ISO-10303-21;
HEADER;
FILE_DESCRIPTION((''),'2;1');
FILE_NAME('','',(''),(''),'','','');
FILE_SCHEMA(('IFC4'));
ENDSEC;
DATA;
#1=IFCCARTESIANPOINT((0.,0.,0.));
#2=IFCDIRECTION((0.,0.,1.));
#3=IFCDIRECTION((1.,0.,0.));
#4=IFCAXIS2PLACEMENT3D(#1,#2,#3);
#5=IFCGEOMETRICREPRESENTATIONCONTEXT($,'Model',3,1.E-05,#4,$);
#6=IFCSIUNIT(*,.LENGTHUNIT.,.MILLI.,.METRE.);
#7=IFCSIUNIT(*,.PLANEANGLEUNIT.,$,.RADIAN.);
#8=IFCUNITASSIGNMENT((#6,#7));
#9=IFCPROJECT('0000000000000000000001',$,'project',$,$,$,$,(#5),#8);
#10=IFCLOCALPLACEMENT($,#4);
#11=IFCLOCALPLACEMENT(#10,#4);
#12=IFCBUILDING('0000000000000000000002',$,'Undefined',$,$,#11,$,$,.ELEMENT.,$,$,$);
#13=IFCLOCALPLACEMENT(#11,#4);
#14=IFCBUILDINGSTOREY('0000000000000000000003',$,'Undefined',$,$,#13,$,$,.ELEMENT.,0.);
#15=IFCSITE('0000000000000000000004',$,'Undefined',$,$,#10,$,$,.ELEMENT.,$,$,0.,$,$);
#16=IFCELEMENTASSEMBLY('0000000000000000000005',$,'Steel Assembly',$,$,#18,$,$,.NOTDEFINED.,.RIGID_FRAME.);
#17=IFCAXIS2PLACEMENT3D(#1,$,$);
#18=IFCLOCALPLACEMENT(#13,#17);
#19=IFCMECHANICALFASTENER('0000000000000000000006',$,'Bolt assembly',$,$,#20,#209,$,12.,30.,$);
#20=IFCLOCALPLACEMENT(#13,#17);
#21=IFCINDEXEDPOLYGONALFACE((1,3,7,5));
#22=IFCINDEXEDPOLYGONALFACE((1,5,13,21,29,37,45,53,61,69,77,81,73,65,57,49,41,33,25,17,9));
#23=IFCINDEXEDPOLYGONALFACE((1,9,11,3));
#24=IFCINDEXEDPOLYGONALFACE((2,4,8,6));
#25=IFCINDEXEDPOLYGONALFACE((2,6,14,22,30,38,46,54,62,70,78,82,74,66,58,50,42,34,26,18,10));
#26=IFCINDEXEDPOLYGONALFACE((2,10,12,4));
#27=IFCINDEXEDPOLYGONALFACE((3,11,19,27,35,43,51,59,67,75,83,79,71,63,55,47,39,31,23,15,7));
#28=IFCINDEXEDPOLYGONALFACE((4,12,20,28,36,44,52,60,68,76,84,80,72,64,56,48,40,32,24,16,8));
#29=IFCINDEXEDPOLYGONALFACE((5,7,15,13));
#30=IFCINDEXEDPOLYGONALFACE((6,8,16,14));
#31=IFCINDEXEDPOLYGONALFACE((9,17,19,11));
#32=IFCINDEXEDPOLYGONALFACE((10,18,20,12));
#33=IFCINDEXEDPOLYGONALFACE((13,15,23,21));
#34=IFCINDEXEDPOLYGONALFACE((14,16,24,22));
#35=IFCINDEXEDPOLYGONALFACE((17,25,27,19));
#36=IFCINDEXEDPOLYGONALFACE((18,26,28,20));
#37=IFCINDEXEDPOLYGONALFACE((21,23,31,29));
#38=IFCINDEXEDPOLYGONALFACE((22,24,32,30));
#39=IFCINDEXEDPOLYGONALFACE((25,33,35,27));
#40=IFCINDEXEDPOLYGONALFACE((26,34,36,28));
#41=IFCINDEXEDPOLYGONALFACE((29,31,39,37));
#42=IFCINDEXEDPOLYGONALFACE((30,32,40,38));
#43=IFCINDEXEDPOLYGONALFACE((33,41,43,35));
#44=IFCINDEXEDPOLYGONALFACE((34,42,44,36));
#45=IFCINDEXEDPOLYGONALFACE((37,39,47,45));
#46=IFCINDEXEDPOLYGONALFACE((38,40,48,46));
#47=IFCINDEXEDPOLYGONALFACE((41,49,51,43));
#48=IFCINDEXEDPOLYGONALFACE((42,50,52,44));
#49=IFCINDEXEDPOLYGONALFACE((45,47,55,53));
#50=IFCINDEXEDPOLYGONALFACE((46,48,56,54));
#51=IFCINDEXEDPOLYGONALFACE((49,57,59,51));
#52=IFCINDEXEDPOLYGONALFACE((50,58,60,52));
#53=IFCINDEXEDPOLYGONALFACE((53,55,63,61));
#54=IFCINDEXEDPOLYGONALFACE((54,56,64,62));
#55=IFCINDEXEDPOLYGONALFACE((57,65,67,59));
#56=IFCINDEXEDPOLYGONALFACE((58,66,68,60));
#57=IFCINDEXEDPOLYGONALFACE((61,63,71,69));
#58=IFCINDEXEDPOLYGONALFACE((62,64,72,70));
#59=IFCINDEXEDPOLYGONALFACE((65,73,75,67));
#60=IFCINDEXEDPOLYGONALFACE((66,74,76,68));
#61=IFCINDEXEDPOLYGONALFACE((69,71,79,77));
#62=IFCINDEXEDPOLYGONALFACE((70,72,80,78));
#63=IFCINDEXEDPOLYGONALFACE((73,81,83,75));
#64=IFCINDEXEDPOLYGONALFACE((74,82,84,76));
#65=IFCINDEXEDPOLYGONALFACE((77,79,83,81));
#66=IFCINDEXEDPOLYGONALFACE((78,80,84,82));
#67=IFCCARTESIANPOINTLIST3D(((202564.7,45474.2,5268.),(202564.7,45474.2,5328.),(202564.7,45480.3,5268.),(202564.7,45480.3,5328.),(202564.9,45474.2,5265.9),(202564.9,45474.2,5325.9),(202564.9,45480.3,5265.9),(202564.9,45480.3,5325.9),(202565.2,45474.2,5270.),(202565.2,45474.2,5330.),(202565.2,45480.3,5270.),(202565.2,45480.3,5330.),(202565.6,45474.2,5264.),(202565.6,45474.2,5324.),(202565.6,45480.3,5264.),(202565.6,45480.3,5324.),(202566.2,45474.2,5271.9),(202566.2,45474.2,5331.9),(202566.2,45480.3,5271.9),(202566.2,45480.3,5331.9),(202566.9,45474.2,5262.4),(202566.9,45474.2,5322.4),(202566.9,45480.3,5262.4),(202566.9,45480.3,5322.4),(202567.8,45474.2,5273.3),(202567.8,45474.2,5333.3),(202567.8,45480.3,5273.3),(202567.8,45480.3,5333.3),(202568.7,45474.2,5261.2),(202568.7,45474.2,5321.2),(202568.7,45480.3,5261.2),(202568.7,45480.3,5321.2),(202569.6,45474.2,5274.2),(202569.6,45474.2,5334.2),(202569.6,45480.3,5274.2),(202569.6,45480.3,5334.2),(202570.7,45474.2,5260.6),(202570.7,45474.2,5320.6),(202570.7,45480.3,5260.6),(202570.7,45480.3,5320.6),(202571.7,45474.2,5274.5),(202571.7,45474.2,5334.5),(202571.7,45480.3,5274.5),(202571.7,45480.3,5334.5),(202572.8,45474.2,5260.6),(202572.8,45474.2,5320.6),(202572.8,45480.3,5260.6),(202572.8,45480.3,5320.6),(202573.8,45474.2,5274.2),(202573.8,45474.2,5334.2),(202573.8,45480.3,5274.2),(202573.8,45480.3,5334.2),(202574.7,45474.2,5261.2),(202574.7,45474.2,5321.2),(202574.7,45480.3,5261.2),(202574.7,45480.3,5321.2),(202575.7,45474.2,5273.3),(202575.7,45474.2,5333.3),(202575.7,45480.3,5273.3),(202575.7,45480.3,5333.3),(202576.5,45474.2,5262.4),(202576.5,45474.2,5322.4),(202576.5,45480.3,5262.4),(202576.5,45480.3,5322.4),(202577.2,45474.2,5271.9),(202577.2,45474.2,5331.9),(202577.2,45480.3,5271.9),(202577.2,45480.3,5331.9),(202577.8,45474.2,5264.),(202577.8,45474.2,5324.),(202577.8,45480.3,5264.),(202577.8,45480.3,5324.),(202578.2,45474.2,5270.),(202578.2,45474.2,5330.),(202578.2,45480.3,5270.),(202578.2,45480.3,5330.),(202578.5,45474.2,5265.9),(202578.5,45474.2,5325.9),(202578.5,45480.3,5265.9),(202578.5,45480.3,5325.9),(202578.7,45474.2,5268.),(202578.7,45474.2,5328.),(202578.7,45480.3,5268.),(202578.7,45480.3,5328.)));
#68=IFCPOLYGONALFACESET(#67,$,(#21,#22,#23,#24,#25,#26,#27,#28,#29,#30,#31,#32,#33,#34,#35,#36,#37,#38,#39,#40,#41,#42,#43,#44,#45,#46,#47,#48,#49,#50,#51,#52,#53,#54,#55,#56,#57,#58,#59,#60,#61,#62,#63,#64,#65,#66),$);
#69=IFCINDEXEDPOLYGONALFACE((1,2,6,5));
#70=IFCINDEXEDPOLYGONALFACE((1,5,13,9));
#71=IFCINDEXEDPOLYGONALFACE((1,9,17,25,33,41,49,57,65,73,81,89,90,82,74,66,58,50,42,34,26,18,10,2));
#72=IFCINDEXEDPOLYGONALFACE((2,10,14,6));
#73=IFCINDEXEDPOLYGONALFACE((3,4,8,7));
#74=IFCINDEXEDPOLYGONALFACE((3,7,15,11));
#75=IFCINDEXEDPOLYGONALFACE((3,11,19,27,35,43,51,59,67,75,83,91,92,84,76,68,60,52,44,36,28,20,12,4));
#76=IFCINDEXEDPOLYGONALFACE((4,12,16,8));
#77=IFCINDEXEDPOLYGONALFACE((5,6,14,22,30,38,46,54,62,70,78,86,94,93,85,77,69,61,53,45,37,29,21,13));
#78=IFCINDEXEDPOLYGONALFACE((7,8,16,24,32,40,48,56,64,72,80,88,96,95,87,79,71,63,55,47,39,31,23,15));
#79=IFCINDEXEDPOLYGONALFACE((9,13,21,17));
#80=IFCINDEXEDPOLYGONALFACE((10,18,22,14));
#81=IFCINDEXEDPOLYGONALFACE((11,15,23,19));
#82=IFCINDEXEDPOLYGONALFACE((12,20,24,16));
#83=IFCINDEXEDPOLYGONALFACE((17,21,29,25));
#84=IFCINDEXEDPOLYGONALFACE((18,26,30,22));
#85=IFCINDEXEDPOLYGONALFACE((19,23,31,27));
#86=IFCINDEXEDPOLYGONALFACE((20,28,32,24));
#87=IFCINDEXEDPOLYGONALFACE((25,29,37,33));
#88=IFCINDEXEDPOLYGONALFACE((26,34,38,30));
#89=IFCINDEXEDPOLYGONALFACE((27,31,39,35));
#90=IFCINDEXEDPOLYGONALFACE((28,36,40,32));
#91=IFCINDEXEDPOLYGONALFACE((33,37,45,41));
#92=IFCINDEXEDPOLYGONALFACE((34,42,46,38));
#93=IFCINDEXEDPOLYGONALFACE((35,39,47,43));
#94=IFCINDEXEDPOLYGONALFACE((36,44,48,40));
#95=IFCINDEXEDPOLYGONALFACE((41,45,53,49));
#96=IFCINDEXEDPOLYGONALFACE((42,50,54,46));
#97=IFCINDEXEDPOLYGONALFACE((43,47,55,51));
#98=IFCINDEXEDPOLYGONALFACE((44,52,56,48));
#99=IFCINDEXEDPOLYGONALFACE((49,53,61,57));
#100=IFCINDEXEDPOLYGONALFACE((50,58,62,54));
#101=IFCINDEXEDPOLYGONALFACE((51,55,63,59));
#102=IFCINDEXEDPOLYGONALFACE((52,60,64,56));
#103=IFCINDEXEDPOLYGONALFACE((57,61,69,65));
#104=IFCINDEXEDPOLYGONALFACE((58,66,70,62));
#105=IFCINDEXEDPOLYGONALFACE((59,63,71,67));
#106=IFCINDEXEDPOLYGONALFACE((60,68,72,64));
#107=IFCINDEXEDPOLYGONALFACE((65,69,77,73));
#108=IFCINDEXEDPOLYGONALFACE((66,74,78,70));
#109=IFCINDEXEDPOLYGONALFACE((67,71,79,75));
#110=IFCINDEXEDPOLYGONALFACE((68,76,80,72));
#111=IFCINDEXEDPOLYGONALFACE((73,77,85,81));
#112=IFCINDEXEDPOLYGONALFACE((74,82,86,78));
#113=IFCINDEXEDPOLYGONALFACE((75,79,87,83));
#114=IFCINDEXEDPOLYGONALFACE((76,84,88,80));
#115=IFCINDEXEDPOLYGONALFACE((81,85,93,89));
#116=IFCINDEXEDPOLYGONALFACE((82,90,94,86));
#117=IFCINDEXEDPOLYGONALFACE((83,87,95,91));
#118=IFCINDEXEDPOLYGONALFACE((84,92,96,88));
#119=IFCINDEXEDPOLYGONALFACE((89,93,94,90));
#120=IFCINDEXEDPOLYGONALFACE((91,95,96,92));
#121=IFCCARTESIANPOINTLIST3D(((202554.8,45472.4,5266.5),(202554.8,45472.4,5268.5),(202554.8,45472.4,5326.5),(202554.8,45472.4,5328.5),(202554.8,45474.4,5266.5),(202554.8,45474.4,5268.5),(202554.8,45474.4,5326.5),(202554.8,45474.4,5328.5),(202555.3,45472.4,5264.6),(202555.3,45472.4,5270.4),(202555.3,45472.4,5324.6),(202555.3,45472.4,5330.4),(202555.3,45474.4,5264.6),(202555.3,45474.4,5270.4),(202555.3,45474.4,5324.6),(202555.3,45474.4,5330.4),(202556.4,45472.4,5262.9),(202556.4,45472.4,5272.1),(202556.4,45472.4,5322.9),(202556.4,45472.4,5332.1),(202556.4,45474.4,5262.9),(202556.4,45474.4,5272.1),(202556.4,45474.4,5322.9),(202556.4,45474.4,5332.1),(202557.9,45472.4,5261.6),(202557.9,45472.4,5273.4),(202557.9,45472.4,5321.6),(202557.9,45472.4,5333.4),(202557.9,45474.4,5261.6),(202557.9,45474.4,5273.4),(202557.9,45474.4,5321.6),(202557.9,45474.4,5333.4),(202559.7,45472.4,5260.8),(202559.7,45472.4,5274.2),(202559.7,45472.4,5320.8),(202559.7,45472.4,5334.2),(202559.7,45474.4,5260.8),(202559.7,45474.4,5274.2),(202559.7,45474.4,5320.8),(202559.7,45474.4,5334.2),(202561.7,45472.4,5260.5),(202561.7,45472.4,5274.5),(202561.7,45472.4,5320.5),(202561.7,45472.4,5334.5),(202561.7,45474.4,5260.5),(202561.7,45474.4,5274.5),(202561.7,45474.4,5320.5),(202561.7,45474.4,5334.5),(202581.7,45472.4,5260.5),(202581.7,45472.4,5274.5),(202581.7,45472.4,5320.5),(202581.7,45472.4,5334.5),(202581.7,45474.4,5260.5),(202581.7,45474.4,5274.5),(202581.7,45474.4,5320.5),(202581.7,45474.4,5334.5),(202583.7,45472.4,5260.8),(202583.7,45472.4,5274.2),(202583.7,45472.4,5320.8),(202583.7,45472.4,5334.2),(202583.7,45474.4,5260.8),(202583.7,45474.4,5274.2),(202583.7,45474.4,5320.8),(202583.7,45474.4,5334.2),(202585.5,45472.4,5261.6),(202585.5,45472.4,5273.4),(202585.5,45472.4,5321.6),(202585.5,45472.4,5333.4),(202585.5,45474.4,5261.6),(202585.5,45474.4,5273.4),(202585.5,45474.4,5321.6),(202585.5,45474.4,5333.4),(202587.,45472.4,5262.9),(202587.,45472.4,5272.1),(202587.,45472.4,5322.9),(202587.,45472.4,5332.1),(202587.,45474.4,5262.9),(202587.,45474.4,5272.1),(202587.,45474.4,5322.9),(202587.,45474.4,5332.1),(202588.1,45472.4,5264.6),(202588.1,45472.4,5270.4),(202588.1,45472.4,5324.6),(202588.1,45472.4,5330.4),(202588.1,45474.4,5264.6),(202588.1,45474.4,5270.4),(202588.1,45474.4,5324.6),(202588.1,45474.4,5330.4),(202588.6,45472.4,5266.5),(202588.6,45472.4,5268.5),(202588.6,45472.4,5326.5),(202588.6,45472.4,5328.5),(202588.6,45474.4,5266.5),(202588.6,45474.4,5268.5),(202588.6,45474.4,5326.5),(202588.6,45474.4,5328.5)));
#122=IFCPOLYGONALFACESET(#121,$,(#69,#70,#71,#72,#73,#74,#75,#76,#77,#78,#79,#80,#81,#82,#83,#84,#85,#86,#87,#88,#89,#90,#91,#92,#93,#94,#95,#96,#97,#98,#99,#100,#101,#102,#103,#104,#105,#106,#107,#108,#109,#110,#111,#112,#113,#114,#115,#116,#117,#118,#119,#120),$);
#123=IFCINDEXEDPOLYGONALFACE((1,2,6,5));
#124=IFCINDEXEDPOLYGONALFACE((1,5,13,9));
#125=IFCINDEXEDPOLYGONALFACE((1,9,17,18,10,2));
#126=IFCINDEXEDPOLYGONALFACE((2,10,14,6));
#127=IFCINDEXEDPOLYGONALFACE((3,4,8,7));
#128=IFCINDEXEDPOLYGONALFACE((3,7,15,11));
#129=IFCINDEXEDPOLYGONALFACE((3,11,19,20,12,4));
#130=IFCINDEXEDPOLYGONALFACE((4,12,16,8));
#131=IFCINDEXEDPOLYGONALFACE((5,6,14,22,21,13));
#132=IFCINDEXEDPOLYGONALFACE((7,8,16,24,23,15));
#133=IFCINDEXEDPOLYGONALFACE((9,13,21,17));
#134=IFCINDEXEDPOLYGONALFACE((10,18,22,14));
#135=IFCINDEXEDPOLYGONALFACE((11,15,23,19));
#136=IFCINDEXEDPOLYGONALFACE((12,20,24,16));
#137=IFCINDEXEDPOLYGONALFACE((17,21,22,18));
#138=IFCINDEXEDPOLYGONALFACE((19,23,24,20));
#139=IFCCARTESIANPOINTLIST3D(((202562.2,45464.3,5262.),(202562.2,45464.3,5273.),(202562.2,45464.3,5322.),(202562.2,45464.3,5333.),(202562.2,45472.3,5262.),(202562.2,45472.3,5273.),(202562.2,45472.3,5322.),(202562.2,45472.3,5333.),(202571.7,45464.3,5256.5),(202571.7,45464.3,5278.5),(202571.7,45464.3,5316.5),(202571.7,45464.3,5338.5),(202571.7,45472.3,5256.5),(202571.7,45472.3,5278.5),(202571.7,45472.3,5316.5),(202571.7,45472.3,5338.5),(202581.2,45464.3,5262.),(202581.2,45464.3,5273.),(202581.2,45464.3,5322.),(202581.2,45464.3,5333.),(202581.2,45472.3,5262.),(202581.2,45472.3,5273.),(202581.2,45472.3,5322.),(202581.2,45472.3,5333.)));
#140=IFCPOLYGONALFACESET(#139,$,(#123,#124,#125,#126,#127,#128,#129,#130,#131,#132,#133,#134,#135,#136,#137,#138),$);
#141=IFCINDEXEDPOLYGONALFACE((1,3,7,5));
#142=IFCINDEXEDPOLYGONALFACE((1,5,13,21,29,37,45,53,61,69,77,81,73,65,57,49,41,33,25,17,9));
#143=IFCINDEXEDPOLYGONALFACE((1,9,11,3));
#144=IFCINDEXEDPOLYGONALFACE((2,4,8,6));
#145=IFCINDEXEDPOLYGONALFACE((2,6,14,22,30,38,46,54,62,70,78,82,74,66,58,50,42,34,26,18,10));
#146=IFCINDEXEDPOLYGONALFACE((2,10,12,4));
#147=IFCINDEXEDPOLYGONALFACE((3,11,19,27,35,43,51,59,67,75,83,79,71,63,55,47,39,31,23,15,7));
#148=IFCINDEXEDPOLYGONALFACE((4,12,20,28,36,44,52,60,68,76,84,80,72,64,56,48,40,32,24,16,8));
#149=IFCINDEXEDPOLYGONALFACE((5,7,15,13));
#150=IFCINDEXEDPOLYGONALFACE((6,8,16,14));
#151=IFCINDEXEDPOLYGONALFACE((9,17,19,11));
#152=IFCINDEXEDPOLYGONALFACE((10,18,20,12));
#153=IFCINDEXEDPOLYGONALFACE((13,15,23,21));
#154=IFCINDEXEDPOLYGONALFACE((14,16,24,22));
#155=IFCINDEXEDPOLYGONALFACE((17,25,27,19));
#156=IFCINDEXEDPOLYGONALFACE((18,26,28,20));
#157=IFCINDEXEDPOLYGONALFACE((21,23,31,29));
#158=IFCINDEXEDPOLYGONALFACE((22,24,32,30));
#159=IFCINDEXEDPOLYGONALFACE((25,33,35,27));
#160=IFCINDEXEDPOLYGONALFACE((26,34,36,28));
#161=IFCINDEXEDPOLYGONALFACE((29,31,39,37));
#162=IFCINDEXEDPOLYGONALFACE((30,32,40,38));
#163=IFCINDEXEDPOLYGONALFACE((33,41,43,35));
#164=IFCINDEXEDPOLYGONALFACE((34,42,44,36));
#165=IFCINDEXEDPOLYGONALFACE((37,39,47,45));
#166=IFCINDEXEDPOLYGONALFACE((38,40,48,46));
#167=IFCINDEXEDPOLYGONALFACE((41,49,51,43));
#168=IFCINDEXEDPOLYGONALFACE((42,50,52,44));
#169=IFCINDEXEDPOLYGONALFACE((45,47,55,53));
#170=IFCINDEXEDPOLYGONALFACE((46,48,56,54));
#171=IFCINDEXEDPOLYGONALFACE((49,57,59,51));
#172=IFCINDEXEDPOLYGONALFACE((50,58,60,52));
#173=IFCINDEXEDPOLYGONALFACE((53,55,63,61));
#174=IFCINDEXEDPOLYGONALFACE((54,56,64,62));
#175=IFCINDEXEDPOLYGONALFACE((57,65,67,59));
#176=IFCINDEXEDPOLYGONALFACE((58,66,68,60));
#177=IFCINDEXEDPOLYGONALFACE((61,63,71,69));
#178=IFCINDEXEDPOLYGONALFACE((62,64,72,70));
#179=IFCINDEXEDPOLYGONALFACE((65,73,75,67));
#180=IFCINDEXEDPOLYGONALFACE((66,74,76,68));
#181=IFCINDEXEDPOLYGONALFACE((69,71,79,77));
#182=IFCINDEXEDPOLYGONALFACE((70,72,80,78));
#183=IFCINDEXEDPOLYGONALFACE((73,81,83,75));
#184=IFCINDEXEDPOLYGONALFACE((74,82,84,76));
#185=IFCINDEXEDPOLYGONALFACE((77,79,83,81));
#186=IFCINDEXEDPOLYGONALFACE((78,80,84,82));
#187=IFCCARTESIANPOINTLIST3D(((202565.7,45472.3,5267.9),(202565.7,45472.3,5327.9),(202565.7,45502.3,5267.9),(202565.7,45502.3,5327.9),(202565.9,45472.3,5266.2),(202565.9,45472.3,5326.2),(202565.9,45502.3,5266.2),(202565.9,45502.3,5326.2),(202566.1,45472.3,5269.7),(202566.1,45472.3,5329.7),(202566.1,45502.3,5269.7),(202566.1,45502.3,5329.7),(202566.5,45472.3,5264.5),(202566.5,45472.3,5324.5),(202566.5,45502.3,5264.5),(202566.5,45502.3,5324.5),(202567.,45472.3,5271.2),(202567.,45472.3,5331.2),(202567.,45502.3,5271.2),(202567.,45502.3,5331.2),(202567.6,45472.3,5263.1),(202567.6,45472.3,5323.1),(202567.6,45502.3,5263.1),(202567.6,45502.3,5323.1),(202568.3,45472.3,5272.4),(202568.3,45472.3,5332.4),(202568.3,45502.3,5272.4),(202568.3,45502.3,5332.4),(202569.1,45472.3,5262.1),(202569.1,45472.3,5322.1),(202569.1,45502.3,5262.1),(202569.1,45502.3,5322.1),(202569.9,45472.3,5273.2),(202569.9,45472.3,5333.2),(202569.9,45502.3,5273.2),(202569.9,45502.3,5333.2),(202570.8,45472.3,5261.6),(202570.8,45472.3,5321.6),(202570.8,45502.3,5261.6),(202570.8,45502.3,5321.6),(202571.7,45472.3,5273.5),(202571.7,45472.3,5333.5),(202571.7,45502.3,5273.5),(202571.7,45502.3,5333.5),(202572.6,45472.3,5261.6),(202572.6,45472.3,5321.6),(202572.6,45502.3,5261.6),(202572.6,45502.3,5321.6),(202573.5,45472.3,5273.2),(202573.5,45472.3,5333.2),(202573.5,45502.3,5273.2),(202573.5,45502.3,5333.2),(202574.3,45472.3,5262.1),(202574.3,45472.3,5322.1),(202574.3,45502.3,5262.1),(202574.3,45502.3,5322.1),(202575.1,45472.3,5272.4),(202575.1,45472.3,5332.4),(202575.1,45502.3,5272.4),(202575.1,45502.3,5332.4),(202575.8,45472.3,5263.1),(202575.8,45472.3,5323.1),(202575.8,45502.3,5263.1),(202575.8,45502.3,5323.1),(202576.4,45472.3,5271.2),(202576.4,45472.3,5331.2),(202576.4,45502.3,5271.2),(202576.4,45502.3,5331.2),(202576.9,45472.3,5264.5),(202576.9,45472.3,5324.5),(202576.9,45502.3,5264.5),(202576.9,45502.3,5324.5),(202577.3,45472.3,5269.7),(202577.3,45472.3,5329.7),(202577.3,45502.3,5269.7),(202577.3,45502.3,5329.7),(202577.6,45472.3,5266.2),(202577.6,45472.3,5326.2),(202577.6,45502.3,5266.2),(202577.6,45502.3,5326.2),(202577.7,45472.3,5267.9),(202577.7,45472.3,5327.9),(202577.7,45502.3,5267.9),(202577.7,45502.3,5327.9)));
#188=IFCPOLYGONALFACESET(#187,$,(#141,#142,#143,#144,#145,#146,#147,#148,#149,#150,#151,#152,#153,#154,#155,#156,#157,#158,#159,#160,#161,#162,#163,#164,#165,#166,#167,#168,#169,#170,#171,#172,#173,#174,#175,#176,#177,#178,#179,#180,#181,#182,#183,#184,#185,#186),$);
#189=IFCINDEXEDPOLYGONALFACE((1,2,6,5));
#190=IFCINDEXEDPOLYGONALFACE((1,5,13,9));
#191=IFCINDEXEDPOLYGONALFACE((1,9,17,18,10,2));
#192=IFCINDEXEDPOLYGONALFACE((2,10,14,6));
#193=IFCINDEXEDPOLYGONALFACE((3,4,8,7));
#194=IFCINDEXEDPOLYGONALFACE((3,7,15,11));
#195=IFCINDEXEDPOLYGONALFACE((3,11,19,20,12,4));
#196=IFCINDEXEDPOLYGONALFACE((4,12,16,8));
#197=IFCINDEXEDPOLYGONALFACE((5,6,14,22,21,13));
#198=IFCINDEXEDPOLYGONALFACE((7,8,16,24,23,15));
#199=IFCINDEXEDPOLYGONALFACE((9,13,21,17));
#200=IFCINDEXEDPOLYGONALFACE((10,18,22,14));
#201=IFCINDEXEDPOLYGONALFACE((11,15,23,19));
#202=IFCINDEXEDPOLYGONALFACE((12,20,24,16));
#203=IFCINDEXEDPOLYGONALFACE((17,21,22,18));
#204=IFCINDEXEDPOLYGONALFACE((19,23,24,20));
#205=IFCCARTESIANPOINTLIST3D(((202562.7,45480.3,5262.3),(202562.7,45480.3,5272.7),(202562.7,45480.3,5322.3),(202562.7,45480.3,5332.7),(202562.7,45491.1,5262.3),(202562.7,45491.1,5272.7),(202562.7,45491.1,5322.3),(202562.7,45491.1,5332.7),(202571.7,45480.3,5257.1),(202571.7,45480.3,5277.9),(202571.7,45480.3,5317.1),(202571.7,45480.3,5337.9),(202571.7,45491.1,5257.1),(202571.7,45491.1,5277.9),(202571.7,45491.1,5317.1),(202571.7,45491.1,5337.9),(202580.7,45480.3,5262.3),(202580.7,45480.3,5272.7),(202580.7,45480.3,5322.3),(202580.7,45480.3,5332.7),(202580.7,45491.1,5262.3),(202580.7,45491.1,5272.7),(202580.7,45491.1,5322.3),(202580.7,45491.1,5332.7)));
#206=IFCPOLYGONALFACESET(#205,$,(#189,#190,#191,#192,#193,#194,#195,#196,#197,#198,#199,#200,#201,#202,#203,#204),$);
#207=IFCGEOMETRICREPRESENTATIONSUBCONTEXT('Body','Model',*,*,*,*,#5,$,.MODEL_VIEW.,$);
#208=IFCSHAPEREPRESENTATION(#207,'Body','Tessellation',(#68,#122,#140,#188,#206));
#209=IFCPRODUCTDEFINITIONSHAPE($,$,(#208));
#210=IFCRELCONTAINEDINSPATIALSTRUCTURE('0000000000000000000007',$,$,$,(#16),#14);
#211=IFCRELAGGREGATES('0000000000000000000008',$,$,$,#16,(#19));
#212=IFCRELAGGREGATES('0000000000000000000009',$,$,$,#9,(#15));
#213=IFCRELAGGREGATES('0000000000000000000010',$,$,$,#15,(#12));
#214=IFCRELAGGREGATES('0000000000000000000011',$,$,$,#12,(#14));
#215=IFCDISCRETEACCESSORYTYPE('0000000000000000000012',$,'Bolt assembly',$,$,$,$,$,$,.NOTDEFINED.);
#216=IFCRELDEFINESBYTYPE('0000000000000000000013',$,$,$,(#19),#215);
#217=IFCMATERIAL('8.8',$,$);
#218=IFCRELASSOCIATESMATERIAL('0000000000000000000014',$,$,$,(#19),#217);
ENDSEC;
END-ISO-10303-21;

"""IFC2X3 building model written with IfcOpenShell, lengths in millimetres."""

from ifc_helpers import new_model, si_unit, frame, frame_2d, origin_with_axes, origin_2d_with_axis, place, context, subcontext, project, spatial, polyline, circle_curve, parameter, trimmed, segment, composite_curve, circle, outline, extrude, source, transform, mapped, material, type_object, element, aggregate, save


model = new_model("IFC2X3")

# Units and contexts
model_context = context("Model", 3, precision=1e-05, world=origin_with_axes())
body_context = subcontext(model_context, "Body", "Model", "MODEL_VIEW")
ifc_project = project(units=[si_unit("LENGTHUNIT", "METRE", prefix="MILLI"), si_unit("PLANEANGLEUNIT", "RADIAN")], contexts=[model_context])

# Site, building, storey
site_placement = place(None, origin_with_axes())
site = spatial("IfcSite", under=ifc_project, at=site_placement, Name="Undefined", CompositionType="ELEMENT", RefElevation=0.0)
building_placement = place(site_placement, origin_with_axes())
building = spatial("IfcBuilding", under=site, at=building_placement, Name="Undefined", CompositionType="ELEMENT")
storey_placement = place(building_placement, origin_with_axes())
storey = spatial("IfcBuildingStorey", under=building, at=storey_placement, Name="Undefined", CompositionType="ELEMENT", Elevation=0.0)

# Shared definitions
discrete_accessory_type_1 = type_object("IfcDiscreteAccessoryType", Name="Bolt assembly")
ifc_material_1 = material(Name="8.8")

# Element assembly, mechanical fastener
assembly_1_placement = place(storey_placement, origin_with_axes())
assembly_1 = element("IfcElementAssembly", 1, at=assembly_1_placement, inside=storey, Name="Steel Assembly", AssemblyPlace="NOTDEFINED", PredefinedType="RIGID_FRAME")
shared_shape_1 = source(origin_with_axes(), body_context, "Body", "SweptSolid", [
    extrude(circle(Radius=7.0, at=origin_2d_with_axis()), frame((0.0, -3.1, 0.0), z_axis=(0.0, 1.0, 0.0), x_axis=(1.0, 0.0, 0.0)), (0.0, 0.0, 1.0), 6.1),
    extrude(outline(composite_curve([segment(polyline([(7.0, 10.0), (7.0, -10.0)]), True, "CONTINUOUS"), segment(trimmed(circle_curve(frame_2d((0.0, -10.0), x_axis=(1.0, 0.0)), 7.0), [parameter(0.0)], [parameter(3.1416)], False, "PARAMETER"), True, "CONTINUOUS"), segment(polyline([(-7.0, -10.0), (-7.0, 10.0)]), True, "CONTINUOUS"), segment(trimmed(circle_curve(frame_2d((0.0, 10.0), x_axis=(-1.0, 0.0)), 7.0), [parameter(0.0)], [parameter(3.1416)], False, "PARAMETER"), True, "DISCONTINUOUS")], self_intersect=False)), frame((0.0, -4.9, 0.0), z_axis=(0.0, 1.0, 0.0), x_axis=(1.0, 0.0, 0.0)), (0.0, 0.0, 1.0), 2.0),
    extrude(outline(polyline([(11.0, 0.0), (5.5, 9.5), (-5.5, 9.5), (-11.0, 0.0), (-5.5, -9.5), (5.5, -9.5), (11.0, 0.0)])), frame((0.0, -13.0, 0.0), z_axis=(0.0, 1.0, 0.0), x_axis=(1.0, 0.0, 0.0)), (0.0, 0.0, 1.0), 8.0),
    extrude(circle(Radius=6.0, at=origin_2d_with_axis()), frame((0.0, -5.0, 0.0), z_axis=(0.0, 1.0, 0.0), x_axis=(1.0, 0.0, 0.0)), (0.0, 0.0, 1.0), 30.0),
    extrude(outline(polyline([(10.4, 0.0), (5.2, 9.0), (-5.2, 9.0), (-10.4, 0.0), (-5.2, -9.0), (5.2, -9.0), (10.4, 0.0)])), frame((0.0, 3.0, 0.0), z_axis=(0.0, 1.0, 0.0), x_axis=(1.0, 0.0, 0.0)), (0.0, 0.0, 1.0), 10.8),
])
mechanical_fastener_1_placement = place(assembly_1_placement, frame((202616.7, 45477.3, 5222.5), z_axis=(-1.0, 0.0, 0.0), x_axis=(0.0, 0.0, 1.0)))
mechanical_fastener_1 = element("IfcMechanicalFastener", 2, at=mechanical_fastener_1_placement, type_object=discrete_accessory_type_1, material=ifc_material_1, Name="Bolt assembly", NominalDiameter=12.0, NominalLength=30.0, context=body_context, shape_type="MappedRepresentation", body=[
    mapped(shared_shape_1, transform((45.0, 0.0, 45.0))),
    mapped(shared_shape_1, transform((105.0, 0.0, 45.0))),
])
aggregate(assembly_1, [mechanical_fastener_1])

save(model, "model.ifc")
